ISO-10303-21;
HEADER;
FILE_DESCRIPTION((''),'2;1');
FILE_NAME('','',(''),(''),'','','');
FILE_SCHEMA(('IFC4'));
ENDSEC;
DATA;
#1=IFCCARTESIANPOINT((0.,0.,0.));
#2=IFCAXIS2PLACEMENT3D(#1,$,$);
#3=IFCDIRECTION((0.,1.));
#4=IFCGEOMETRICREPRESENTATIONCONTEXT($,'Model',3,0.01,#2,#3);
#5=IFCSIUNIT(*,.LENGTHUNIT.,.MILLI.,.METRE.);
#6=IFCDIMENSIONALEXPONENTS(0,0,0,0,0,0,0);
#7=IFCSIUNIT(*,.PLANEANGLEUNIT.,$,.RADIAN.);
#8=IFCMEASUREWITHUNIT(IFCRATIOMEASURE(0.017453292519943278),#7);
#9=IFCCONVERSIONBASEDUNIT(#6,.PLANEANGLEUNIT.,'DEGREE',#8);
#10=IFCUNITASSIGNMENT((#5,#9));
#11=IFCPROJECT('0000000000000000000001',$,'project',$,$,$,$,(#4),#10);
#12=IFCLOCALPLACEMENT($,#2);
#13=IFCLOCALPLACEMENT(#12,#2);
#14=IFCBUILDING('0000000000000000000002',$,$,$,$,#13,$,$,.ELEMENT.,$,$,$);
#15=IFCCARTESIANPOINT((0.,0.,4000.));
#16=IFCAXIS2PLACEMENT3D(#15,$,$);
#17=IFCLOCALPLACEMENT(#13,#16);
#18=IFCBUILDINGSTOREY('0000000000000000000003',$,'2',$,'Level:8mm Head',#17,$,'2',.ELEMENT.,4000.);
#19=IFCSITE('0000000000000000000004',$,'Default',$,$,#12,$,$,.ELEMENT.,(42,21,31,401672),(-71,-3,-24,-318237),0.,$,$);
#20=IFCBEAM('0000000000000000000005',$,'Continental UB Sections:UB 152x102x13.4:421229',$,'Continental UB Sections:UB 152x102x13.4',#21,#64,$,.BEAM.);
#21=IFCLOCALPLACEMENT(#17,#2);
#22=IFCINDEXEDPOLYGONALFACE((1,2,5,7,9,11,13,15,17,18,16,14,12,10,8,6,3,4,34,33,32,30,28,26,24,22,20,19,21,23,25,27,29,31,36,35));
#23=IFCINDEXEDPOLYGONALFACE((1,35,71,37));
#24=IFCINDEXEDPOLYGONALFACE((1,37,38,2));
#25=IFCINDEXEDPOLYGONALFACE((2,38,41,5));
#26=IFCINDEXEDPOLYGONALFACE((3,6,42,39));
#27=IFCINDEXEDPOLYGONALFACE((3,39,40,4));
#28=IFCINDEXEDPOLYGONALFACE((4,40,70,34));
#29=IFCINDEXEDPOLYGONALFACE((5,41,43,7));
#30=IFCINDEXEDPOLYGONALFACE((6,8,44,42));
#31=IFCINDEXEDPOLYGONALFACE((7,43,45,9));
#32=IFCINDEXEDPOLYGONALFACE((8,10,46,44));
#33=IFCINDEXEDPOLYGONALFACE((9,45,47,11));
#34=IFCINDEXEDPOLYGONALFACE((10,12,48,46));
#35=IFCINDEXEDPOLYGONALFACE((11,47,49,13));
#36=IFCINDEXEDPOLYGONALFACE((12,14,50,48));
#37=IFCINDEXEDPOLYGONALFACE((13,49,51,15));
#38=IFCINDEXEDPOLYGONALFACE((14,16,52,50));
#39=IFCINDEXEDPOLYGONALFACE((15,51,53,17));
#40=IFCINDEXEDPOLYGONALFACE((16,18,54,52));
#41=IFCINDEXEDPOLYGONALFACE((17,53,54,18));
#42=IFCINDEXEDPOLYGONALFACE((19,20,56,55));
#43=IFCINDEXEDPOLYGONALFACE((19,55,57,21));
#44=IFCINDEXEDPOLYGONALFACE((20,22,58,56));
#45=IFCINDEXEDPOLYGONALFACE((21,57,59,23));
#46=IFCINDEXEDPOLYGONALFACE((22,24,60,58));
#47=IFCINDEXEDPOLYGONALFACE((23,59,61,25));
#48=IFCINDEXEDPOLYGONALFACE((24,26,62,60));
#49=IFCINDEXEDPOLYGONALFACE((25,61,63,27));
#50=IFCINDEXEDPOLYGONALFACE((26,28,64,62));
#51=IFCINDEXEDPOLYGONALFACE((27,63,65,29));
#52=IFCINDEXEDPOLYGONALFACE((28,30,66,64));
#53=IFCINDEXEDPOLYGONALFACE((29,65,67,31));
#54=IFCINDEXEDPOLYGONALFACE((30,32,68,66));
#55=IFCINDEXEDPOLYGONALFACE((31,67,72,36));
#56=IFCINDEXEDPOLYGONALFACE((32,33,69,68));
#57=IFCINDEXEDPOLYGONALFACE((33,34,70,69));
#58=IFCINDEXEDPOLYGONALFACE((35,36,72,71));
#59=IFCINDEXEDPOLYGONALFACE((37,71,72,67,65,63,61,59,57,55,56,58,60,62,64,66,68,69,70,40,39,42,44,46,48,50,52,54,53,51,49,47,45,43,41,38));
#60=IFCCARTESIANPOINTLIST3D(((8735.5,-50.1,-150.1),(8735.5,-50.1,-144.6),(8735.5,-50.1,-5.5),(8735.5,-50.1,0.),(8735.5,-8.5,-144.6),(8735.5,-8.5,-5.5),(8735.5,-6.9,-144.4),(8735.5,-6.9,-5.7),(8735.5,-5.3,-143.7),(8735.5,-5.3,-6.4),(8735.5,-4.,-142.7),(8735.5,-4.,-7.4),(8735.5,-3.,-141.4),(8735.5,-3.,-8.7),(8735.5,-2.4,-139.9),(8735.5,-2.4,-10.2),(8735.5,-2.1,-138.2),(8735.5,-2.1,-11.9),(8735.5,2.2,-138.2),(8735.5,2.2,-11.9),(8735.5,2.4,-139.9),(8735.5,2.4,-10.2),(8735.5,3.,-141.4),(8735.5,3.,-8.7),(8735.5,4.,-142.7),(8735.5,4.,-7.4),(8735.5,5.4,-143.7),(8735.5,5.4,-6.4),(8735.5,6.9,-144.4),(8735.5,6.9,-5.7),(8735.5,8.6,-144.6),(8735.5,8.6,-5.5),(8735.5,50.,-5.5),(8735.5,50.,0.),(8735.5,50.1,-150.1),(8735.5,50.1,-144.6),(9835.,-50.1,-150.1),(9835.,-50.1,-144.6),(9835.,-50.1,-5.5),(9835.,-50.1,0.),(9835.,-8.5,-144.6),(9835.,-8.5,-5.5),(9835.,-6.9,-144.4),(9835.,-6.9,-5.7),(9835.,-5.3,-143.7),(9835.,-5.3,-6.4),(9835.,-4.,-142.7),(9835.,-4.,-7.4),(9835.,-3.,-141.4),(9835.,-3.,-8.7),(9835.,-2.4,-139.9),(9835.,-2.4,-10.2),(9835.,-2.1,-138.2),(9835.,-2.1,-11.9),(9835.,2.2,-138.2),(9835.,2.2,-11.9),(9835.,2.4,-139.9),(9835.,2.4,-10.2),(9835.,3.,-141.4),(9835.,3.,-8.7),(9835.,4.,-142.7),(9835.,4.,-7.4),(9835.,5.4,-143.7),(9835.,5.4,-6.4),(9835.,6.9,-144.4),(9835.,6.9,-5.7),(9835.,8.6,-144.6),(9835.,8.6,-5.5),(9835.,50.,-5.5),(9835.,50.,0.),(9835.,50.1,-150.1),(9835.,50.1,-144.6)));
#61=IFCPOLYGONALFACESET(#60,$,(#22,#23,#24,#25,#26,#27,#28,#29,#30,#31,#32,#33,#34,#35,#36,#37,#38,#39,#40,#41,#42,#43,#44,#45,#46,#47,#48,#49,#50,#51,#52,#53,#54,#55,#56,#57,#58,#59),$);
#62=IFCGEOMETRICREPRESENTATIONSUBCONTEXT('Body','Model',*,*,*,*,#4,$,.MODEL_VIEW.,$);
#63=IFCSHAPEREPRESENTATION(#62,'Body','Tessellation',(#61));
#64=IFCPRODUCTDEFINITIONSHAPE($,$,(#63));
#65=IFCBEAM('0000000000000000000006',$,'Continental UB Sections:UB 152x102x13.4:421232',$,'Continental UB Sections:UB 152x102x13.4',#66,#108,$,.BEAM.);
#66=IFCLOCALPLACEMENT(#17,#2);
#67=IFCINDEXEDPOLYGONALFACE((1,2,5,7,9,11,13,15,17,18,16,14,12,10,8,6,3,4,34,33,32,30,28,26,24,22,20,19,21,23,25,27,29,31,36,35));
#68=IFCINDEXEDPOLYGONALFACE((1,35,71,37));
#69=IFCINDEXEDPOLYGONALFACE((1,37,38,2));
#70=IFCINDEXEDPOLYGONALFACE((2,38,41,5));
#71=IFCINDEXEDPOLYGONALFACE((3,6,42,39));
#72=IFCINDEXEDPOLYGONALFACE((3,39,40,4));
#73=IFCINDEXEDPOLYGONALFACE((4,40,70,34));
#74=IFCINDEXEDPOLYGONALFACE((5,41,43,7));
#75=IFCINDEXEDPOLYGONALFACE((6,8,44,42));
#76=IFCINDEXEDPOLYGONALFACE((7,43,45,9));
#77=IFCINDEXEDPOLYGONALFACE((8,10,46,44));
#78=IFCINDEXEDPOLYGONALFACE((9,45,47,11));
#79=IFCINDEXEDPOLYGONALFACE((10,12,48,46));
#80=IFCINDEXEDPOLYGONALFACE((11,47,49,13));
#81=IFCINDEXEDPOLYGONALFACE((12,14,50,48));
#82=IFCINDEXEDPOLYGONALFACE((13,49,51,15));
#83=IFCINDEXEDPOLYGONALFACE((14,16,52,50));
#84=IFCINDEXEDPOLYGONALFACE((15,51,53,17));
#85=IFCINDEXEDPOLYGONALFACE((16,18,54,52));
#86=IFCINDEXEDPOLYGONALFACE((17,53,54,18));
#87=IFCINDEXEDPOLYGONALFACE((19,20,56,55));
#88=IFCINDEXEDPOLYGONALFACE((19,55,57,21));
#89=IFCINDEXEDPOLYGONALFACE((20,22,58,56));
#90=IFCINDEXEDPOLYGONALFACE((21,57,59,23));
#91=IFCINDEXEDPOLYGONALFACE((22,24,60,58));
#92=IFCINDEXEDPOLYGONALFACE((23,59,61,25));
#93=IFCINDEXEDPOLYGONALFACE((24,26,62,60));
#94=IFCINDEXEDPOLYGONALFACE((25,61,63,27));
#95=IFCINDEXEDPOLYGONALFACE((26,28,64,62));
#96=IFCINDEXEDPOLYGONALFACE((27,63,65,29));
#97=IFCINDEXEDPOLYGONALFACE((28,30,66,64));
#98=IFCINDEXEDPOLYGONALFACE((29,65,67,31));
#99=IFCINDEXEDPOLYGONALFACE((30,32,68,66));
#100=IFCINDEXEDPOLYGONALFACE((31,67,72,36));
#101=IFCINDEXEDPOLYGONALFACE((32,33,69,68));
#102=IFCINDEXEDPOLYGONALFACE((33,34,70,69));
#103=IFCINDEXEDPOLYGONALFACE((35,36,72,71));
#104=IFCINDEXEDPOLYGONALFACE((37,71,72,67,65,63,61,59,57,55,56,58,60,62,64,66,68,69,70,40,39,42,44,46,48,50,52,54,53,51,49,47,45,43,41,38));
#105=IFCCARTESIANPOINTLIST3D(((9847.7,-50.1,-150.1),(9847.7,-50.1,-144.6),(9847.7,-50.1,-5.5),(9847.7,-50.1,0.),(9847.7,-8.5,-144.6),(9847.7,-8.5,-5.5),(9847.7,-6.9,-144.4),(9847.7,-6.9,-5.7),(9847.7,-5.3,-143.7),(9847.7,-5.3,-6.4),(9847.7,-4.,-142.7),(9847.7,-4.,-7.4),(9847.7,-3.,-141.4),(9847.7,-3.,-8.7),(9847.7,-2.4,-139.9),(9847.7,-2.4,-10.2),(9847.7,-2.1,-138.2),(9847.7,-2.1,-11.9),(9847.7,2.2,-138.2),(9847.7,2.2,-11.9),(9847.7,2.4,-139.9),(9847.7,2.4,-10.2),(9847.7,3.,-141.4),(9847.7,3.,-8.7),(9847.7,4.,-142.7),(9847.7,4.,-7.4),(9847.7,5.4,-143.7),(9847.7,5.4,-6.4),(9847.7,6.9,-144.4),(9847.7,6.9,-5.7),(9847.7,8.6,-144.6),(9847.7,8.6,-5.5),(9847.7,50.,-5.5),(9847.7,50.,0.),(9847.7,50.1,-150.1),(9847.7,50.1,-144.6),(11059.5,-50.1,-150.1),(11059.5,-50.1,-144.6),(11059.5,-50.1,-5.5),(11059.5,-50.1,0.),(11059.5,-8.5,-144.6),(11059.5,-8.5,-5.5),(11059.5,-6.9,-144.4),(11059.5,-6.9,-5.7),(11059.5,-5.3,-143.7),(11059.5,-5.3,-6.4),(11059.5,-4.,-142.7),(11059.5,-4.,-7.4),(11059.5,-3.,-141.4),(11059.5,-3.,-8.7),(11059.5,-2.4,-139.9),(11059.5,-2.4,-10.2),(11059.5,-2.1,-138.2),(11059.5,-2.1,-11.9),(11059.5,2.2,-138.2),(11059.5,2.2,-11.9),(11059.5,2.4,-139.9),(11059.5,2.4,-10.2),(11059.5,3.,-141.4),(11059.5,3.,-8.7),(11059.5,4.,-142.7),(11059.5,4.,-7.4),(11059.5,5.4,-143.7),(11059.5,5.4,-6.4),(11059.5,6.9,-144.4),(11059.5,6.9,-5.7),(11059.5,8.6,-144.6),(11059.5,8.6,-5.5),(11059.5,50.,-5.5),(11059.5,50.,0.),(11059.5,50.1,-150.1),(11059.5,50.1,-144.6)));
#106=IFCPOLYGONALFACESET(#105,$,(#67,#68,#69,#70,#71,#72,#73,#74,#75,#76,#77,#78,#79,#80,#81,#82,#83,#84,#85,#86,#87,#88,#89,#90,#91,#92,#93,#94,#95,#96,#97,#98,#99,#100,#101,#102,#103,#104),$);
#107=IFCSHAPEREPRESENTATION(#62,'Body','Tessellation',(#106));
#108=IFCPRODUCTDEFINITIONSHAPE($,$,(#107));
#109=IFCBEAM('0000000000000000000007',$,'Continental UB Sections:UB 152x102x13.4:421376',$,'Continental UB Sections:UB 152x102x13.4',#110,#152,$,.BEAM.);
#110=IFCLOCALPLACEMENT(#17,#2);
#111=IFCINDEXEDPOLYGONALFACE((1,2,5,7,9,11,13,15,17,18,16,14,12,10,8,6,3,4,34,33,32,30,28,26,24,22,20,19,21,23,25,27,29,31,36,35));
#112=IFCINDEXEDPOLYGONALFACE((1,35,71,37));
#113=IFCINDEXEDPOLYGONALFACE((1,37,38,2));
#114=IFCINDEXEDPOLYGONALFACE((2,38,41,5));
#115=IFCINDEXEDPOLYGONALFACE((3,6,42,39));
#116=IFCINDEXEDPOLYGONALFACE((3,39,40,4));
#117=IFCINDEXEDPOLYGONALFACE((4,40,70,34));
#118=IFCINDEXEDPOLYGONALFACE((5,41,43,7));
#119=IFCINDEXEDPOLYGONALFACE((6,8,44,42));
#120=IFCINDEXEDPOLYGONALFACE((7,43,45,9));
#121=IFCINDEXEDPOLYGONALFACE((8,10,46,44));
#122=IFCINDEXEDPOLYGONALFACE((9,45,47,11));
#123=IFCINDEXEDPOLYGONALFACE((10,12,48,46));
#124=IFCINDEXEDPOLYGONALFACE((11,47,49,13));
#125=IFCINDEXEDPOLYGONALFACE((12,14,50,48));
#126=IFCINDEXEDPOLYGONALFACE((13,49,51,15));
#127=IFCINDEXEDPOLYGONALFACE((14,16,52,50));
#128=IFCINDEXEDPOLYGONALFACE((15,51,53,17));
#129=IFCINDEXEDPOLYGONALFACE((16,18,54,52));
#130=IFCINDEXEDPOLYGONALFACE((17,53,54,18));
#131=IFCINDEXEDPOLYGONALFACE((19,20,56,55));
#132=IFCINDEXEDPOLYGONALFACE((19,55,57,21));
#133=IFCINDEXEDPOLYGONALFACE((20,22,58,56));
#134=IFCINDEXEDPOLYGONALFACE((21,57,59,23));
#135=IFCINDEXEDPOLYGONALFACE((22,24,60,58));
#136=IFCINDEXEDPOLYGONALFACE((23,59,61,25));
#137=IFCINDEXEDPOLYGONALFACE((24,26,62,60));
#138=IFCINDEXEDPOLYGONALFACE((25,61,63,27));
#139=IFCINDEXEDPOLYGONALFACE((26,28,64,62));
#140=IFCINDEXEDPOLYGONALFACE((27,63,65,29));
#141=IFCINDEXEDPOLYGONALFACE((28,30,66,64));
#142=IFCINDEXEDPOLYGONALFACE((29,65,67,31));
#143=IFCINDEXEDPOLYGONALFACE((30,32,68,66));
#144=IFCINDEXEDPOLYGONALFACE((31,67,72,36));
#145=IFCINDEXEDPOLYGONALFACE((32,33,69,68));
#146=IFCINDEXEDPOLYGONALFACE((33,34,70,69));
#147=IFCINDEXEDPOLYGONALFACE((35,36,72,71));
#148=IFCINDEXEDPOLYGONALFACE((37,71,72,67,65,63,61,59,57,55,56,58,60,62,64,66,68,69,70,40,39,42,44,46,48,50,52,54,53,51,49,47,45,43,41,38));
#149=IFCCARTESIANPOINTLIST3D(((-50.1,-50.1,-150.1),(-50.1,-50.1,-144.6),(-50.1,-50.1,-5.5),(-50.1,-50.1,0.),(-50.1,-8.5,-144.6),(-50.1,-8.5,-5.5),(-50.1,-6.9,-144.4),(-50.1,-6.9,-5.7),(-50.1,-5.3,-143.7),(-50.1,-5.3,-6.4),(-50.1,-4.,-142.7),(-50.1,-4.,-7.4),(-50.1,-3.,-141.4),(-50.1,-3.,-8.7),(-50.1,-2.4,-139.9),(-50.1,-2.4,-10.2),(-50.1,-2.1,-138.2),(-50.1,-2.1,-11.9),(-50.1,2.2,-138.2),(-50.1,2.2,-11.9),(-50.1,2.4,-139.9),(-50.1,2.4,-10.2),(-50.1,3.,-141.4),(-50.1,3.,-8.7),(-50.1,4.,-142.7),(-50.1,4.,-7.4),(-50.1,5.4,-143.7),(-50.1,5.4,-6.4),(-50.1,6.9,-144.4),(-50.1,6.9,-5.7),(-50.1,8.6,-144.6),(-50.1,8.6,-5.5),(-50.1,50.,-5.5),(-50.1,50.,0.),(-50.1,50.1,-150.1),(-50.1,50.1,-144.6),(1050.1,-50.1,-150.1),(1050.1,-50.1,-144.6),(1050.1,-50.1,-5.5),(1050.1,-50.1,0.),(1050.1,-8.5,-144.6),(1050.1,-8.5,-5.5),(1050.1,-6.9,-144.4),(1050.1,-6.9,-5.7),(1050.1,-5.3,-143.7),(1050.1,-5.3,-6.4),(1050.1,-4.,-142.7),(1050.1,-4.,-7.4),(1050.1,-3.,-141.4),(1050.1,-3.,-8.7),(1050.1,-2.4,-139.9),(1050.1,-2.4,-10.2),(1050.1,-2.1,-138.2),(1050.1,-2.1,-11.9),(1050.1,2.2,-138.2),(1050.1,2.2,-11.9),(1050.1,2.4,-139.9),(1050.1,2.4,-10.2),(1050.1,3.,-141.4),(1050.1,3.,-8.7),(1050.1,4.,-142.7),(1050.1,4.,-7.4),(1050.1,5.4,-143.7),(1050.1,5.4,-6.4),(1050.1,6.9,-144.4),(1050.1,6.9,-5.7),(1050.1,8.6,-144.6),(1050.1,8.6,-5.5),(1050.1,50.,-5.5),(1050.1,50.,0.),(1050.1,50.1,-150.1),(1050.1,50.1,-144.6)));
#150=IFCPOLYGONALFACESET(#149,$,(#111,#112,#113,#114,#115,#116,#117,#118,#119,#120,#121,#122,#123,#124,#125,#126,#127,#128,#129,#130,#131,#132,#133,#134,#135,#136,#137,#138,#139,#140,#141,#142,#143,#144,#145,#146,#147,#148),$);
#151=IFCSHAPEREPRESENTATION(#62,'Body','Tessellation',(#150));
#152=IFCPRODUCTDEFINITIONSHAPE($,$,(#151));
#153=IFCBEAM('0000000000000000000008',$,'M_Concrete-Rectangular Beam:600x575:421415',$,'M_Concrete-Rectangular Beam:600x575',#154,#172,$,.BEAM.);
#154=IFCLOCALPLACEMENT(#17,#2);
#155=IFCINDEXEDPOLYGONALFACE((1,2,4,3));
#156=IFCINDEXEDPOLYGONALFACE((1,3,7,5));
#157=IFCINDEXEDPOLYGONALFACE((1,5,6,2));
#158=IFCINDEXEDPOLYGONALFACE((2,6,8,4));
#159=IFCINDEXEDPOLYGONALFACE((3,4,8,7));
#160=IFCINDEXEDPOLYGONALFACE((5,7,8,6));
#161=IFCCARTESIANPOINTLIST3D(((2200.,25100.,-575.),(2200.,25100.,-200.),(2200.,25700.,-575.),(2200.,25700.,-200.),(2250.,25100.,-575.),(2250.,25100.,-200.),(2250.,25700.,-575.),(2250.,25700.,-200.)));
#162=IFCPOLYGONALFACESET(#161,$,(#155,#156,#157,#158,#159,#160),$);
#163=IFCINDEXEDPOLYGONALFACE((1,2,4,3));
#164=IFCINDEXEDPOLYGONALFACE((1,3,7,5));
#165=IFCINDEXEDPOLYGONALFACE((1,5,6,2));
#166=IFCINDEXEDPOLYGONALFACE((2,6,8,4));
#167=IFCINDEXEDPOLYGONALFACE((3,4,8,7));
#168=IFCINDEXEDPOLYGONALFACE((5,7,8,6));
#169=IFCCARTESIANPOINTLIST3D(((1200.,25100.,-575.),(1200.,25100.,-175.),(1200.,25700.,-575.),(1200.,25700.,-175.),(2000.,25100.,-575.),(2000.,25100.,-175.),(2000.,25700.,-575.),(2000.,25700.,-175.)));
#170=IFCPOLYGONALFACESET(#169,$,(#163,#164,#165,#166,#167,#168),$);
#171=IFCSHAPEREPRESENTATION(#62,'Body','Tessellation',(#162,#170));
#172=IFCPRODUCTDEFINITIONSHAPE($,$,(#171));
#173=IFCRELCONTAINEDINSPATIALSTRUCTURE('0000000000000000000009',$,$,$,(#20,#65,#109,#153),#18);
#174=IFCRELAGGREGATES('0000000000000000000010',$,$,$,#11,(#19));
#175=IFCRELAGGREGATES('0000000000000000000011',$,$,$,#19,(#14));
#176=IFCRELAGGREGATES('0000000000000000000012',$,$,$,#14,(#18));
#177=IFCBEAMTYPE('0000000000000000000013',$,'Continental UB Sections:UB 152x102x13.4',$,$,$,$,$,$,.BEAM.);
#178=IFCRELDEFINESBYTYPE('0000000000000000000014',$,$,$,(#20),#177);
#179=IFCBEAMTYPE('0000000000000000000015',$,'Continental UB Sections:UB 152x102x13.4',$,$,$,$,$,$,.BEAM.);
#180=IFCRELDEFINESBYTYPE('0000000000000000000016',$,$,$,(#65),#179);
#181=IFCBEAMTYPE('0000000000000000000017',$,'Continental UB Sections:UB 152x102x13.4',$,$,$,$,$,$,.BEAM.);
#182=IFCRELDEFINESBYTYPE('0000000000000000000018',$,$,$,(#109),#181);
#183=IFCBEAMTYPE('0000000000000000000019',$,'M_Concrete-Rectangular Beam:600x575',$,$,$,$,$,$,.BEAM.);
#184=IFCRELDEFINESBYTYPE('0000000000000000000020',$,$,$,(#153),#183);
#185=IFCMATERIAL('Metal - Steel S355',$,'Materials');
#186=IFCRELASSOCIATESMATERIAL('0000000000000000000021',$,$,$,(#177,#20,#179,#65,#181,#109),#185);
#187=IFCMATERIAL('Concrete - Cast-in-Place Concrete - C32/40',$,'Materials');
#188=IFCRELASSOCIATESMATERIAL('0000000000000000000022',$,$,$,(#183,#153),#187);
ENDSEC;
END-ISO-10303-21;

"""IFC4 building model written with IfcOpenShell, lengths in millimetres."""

from ifc_helpers import new_model, entity, si_unit, converted_unit, direction, frame, origin, place, context, subcontext, project, spatial, line, arc, indexed_curve, outline, extrude, source, transform, mapped, material, type_object, type_shapes, element, save


model = new_model("IFC4")

# Units and contexts
model_context = context("Model", 3, precision=0.01, world=origin(), true_north=direction((0.0, 1.0)))
body_context = subcontext(model_context, "Body", "Model", "MODEL_VIEW")
ifc_project = project(units=[si_unit("LENGTHUNIT", "METRE", prefix="MILLI"), converted_unit("PLANEANGLEUNIT", "DEGREE", entity("IfcRatioMeasure", 0.017453292519943278), si_unit("PLANEANGLEUNIT", "RADIAN"), dimensions=[0, 0, 0, 0, 0, 0, 0])], contexts=[model_context])

# Site, building, storey
site_placement = place(None, origin())
site = spatial("IfcSite", under=ifc_project, at=site_placement, Name="Default", CompositionType="ELEMENT", RefLatitude=(42, 21, 31, 401672), RefLongitude=(-71, -3, -24, -318237), RefElevation=0.0)
building_placement = place(site_placement, origin())
building = spatial("IfcBuilding", under=site, at=building_placement, CompositionType="ELEMENT")
storey_placement = place(building_placement, frame((0.0, 0.0, 4000.0)))
storey = spatial("IfcBuildingStorey", under=building, at=storey_placement, Name="2", ObjectType="Level:8mm Head", LongName="2", CompositionType="ELEMENT", Elevation=4000.0)

# Beams
ifc_material_1 = material(Name="Metal - Steel S355", Category="Materials")
beam_type_1 = type_object("IfcBeamType", Name="Continental UB Sections:UB 152x102x13.4", PredefinedType="BEAM", material=ifc_material_1)
shared_shape_1 = source(origin(), body_context, "Body", "SweptSolid", [
    extrude(outline(indexed_curve([(-75.0, -50.1), (-69.6, -50.1), (-69.6, -8.5), (-67.7, -4.0), (-63.2, -2.1), (63.1, -2.1), (67.7, -4.0), (69.5, -8.5), (69.5, -50.1), (75.1, -50.1), (75.1, 50.1), (69.5, 50.1), (69.5, 8.6), (67.7, 4.0), (63.1, 2.2), (-63.2, 2.2), (-67.7, 4.0), (-69.6, 8.6), (-69.6, 50.0), (-75.0, 50.0)], segments=[line(1, 2, 3), arc(3, 4, 5), line(5, 6), arc(6, 7, 8), line(8, 9, 10, 11, 12, 13), arc(13, 14, 15), line(15, 16), arc(16, 17, 18), line(18, 19, 20, 1)], self_intersect=False)), frame((-606.2, 0.0, 0.0), z_axis=(1.0, 0.0, 0.0), x_axis=(0.0, 0.0, -1.0)), (0.0, 0.0, 1.0), 1099.5),
])
type_shapes(beam_type_1, [shared_shape_1])
for number, where, name in (
    (1, (9341.7, 0.0, -75.1), "Continental UB Sections:UB 152x102x13.4:421229"),
):
    element("IfcBeam", number, at=place(storey_placement, frame(where)), inside=storey, type_object=beam_type_1, material=ifc_material_1, Name=name, ObjectType="Continental UB Sections:UB 152x102x13.4", PredefinedType="BEAM", context=body_context, shape_type="MappedRepresentation", body=[
        mapped(shared_shape_1, transform((0.0, 0.0, 0.0), scale=1.0)),
    ])
beam_type_2 = type_object("IfcBeamType", Name="Continental UB Sections:UB 152x102x13.4", PredefinedType="BEAM", material=ifc_material_1)
shared_shape_2 = source(origin(), body_context, "Body", "SweptSolid", [
    extrude(outline(indexed_curve([(-75.0, -50.1), (-69.6, -50.1), (-69.6, -8.5), (-67.7, -4.0), (-63.2, -2.1), (63.1, -2.1), (67.7, -4.0), (69.5, -8.5), (69.5, -50.1), (75.1, -50.1), (75.1, 50.1), (69.5, 50.1), (69.5, 8.6), (67.7, 4.0), (63.1, 2.2), (-63.2, 2.2), (-67.7, 4.0), (-69.6, 8.6), (-69.6, 50.0), (-75.0, 50.0)], segments=[line(1, 2, 3), arc(3, 4, 5), line(5, 6), arc(6, 7, 8), line(8, 9, 10, 11, 12, 13), arc(13, 14, 15), line(15, 16), arc(16, 17, 18), line(18, 19, 20, 1)], self_intersect=False)), frame((-606.2, 0.0, 0.0), z_axis=(1.0, 0.0, 0.0), x_axis=(0.0, 0.0, -1.0)), (0.0, 0.0, 1.0), 1211.8),
])
type_shapes(beam_type_2, [shared_shape_2])
beam_1_placement = place(storey_placement, frame((10453.9, 0.0, -75.1)))
element("IfcBeam", 2, at=beam_1_placement, inside=storey, type_object=beam_type_2, material=ifc_material_1, Name="Continental UB Sections:UB 152x102x13.4:421232", ObjectType="Continental UB Sections:UB 152x102x13.4", PredefinedType="BEAM", context=body_context, shape_type="MappedRepresentation", body=[
    mapped(shared_shape_2, transform((0.0, 0.0, 0.0), scale=1.0)),
])
beam_type_3 = type_object("IfcBeamType", Name="Continental UB Sections:UB 152x102x13.4", PredefinedType="BEAM", material=ifc_material_1)
shared_shape_3 = source(origin(), body_context, "Body", "SweptSolid", [
    extrude(outline(indexed_curve([(-75.0, -50.1), (-69.6, -50.1), (-69.6, -8.5), (-67.7, -4.0), (-63.2, -2.1), (63.1, -2.1), (67.7, -4.0), (69.5, -8.5), (69.5, -50.1), (75.1, -50.1), (75.1, 50.1), (69.5, 50.1), (69.5, 8.6), (67.7, 4.0), (63.1, 2.2), (-63.2, 2.2), (-67.7, 4.0), (-69.6, 8.6), (-69.6, 50.0), (-75.0, 50.0)], segments=[line(1, 2, 3), arc(3, 4, 5), line(5, 6), arc(6, 7, 8), line(8, 9, 10, 11, 12, 13), arc(13, 14, 15), line(15, 16), arc(16, 17, 18), line(18, 19, 20, 1)], self_intersect=False)), frame((-550.1, 0.0, 0.0), z_axis=(1.0, 0.0, 0.0), x_axis=(0.0, 0.0, -1.0)), (0.0, 0.0, 1.0), 1100.2),
])
type_shapes(beam_type_3, [shared_shape_3])
beam_2_placement = place(storey_placement, frame((500.0, 0.0, -75.1)))
element("IfcBeam", 3, at=beam_2_placement, inside=storey, type_object=beam_type_3, material=ifc_material_1, Name="Continental UB Sections:UB 152x102x13.4:421376", ObjectType="Continental UB Sections:UB 152x102x13.4", PredefinedType="BEAM", context=body_context, shape_type="MappedRepresentation", body=[
    mapped(shared_shape_3, transform((0.0, 0.0, 0.0), scale=1.0)),
])
ifc_material_2 = material(Name="Concrete - Cast-in-Place Concrete - C32/40", Category="Materials")
beam_type_4 = type_object("IfcBeamType", Name="M_Concrete-Rectangular Beam:600x575", PredefinedType="BEAM", material=ifc_material_2)
shared_shape_4 = source(origin(), body_context, "Body", "SweptSolid", [
    extrude(outline(indexed_curve([(-187.5, -300.0), (187.5, -300.0), (187.5, 300.0), (-187.5, 300.0), (-187.5, -300.0)], self_intersect=False)), frame((2200.0, 25400.0, 3612.5), z_axis=(1.0, 0.0, 0.0), x_axis=(0.0, 0.0, -1.0)), (0.0, 0.0, 1.0), 50.0),
    extrude(outline(indexed_curve([(-200.0, -300.0), (200.0, -300.0), (200.0, 300.0), (-200.0, 300.0), (-200.0, -300.0)], self_intersect=False)), frame((1200.0, 25400.0, 3625.0), z_axis=(1.0, 0.0, 0.0), x_axis=(0.0, 0.0, -1.0)), (0.0, 0.0, 1.0), 800.0),
])
type_shapes(beam_type_4, [shared_shape_4])
beam_3_placement = place(storey_placement, frame((0.0, 0.0, -4000.0)))
element("IfcBeam", 4, at=beam_3_placement, inside=storey, type_object=beam_type_4, material=ifc_material_2, Name="M_Concrete-Rectangular Beam:600x575:421415", ObjectType="M_Concrete-Rectangular Beam:600x575", PredefinedType="BEAM", context=body_context, shape_type="MappedRepresentation", body=[
    mapped(shared_shape_4, transform((0.0, 0.0, 0.0), scale=1.0)),
])

save(model, "model.ifc")
